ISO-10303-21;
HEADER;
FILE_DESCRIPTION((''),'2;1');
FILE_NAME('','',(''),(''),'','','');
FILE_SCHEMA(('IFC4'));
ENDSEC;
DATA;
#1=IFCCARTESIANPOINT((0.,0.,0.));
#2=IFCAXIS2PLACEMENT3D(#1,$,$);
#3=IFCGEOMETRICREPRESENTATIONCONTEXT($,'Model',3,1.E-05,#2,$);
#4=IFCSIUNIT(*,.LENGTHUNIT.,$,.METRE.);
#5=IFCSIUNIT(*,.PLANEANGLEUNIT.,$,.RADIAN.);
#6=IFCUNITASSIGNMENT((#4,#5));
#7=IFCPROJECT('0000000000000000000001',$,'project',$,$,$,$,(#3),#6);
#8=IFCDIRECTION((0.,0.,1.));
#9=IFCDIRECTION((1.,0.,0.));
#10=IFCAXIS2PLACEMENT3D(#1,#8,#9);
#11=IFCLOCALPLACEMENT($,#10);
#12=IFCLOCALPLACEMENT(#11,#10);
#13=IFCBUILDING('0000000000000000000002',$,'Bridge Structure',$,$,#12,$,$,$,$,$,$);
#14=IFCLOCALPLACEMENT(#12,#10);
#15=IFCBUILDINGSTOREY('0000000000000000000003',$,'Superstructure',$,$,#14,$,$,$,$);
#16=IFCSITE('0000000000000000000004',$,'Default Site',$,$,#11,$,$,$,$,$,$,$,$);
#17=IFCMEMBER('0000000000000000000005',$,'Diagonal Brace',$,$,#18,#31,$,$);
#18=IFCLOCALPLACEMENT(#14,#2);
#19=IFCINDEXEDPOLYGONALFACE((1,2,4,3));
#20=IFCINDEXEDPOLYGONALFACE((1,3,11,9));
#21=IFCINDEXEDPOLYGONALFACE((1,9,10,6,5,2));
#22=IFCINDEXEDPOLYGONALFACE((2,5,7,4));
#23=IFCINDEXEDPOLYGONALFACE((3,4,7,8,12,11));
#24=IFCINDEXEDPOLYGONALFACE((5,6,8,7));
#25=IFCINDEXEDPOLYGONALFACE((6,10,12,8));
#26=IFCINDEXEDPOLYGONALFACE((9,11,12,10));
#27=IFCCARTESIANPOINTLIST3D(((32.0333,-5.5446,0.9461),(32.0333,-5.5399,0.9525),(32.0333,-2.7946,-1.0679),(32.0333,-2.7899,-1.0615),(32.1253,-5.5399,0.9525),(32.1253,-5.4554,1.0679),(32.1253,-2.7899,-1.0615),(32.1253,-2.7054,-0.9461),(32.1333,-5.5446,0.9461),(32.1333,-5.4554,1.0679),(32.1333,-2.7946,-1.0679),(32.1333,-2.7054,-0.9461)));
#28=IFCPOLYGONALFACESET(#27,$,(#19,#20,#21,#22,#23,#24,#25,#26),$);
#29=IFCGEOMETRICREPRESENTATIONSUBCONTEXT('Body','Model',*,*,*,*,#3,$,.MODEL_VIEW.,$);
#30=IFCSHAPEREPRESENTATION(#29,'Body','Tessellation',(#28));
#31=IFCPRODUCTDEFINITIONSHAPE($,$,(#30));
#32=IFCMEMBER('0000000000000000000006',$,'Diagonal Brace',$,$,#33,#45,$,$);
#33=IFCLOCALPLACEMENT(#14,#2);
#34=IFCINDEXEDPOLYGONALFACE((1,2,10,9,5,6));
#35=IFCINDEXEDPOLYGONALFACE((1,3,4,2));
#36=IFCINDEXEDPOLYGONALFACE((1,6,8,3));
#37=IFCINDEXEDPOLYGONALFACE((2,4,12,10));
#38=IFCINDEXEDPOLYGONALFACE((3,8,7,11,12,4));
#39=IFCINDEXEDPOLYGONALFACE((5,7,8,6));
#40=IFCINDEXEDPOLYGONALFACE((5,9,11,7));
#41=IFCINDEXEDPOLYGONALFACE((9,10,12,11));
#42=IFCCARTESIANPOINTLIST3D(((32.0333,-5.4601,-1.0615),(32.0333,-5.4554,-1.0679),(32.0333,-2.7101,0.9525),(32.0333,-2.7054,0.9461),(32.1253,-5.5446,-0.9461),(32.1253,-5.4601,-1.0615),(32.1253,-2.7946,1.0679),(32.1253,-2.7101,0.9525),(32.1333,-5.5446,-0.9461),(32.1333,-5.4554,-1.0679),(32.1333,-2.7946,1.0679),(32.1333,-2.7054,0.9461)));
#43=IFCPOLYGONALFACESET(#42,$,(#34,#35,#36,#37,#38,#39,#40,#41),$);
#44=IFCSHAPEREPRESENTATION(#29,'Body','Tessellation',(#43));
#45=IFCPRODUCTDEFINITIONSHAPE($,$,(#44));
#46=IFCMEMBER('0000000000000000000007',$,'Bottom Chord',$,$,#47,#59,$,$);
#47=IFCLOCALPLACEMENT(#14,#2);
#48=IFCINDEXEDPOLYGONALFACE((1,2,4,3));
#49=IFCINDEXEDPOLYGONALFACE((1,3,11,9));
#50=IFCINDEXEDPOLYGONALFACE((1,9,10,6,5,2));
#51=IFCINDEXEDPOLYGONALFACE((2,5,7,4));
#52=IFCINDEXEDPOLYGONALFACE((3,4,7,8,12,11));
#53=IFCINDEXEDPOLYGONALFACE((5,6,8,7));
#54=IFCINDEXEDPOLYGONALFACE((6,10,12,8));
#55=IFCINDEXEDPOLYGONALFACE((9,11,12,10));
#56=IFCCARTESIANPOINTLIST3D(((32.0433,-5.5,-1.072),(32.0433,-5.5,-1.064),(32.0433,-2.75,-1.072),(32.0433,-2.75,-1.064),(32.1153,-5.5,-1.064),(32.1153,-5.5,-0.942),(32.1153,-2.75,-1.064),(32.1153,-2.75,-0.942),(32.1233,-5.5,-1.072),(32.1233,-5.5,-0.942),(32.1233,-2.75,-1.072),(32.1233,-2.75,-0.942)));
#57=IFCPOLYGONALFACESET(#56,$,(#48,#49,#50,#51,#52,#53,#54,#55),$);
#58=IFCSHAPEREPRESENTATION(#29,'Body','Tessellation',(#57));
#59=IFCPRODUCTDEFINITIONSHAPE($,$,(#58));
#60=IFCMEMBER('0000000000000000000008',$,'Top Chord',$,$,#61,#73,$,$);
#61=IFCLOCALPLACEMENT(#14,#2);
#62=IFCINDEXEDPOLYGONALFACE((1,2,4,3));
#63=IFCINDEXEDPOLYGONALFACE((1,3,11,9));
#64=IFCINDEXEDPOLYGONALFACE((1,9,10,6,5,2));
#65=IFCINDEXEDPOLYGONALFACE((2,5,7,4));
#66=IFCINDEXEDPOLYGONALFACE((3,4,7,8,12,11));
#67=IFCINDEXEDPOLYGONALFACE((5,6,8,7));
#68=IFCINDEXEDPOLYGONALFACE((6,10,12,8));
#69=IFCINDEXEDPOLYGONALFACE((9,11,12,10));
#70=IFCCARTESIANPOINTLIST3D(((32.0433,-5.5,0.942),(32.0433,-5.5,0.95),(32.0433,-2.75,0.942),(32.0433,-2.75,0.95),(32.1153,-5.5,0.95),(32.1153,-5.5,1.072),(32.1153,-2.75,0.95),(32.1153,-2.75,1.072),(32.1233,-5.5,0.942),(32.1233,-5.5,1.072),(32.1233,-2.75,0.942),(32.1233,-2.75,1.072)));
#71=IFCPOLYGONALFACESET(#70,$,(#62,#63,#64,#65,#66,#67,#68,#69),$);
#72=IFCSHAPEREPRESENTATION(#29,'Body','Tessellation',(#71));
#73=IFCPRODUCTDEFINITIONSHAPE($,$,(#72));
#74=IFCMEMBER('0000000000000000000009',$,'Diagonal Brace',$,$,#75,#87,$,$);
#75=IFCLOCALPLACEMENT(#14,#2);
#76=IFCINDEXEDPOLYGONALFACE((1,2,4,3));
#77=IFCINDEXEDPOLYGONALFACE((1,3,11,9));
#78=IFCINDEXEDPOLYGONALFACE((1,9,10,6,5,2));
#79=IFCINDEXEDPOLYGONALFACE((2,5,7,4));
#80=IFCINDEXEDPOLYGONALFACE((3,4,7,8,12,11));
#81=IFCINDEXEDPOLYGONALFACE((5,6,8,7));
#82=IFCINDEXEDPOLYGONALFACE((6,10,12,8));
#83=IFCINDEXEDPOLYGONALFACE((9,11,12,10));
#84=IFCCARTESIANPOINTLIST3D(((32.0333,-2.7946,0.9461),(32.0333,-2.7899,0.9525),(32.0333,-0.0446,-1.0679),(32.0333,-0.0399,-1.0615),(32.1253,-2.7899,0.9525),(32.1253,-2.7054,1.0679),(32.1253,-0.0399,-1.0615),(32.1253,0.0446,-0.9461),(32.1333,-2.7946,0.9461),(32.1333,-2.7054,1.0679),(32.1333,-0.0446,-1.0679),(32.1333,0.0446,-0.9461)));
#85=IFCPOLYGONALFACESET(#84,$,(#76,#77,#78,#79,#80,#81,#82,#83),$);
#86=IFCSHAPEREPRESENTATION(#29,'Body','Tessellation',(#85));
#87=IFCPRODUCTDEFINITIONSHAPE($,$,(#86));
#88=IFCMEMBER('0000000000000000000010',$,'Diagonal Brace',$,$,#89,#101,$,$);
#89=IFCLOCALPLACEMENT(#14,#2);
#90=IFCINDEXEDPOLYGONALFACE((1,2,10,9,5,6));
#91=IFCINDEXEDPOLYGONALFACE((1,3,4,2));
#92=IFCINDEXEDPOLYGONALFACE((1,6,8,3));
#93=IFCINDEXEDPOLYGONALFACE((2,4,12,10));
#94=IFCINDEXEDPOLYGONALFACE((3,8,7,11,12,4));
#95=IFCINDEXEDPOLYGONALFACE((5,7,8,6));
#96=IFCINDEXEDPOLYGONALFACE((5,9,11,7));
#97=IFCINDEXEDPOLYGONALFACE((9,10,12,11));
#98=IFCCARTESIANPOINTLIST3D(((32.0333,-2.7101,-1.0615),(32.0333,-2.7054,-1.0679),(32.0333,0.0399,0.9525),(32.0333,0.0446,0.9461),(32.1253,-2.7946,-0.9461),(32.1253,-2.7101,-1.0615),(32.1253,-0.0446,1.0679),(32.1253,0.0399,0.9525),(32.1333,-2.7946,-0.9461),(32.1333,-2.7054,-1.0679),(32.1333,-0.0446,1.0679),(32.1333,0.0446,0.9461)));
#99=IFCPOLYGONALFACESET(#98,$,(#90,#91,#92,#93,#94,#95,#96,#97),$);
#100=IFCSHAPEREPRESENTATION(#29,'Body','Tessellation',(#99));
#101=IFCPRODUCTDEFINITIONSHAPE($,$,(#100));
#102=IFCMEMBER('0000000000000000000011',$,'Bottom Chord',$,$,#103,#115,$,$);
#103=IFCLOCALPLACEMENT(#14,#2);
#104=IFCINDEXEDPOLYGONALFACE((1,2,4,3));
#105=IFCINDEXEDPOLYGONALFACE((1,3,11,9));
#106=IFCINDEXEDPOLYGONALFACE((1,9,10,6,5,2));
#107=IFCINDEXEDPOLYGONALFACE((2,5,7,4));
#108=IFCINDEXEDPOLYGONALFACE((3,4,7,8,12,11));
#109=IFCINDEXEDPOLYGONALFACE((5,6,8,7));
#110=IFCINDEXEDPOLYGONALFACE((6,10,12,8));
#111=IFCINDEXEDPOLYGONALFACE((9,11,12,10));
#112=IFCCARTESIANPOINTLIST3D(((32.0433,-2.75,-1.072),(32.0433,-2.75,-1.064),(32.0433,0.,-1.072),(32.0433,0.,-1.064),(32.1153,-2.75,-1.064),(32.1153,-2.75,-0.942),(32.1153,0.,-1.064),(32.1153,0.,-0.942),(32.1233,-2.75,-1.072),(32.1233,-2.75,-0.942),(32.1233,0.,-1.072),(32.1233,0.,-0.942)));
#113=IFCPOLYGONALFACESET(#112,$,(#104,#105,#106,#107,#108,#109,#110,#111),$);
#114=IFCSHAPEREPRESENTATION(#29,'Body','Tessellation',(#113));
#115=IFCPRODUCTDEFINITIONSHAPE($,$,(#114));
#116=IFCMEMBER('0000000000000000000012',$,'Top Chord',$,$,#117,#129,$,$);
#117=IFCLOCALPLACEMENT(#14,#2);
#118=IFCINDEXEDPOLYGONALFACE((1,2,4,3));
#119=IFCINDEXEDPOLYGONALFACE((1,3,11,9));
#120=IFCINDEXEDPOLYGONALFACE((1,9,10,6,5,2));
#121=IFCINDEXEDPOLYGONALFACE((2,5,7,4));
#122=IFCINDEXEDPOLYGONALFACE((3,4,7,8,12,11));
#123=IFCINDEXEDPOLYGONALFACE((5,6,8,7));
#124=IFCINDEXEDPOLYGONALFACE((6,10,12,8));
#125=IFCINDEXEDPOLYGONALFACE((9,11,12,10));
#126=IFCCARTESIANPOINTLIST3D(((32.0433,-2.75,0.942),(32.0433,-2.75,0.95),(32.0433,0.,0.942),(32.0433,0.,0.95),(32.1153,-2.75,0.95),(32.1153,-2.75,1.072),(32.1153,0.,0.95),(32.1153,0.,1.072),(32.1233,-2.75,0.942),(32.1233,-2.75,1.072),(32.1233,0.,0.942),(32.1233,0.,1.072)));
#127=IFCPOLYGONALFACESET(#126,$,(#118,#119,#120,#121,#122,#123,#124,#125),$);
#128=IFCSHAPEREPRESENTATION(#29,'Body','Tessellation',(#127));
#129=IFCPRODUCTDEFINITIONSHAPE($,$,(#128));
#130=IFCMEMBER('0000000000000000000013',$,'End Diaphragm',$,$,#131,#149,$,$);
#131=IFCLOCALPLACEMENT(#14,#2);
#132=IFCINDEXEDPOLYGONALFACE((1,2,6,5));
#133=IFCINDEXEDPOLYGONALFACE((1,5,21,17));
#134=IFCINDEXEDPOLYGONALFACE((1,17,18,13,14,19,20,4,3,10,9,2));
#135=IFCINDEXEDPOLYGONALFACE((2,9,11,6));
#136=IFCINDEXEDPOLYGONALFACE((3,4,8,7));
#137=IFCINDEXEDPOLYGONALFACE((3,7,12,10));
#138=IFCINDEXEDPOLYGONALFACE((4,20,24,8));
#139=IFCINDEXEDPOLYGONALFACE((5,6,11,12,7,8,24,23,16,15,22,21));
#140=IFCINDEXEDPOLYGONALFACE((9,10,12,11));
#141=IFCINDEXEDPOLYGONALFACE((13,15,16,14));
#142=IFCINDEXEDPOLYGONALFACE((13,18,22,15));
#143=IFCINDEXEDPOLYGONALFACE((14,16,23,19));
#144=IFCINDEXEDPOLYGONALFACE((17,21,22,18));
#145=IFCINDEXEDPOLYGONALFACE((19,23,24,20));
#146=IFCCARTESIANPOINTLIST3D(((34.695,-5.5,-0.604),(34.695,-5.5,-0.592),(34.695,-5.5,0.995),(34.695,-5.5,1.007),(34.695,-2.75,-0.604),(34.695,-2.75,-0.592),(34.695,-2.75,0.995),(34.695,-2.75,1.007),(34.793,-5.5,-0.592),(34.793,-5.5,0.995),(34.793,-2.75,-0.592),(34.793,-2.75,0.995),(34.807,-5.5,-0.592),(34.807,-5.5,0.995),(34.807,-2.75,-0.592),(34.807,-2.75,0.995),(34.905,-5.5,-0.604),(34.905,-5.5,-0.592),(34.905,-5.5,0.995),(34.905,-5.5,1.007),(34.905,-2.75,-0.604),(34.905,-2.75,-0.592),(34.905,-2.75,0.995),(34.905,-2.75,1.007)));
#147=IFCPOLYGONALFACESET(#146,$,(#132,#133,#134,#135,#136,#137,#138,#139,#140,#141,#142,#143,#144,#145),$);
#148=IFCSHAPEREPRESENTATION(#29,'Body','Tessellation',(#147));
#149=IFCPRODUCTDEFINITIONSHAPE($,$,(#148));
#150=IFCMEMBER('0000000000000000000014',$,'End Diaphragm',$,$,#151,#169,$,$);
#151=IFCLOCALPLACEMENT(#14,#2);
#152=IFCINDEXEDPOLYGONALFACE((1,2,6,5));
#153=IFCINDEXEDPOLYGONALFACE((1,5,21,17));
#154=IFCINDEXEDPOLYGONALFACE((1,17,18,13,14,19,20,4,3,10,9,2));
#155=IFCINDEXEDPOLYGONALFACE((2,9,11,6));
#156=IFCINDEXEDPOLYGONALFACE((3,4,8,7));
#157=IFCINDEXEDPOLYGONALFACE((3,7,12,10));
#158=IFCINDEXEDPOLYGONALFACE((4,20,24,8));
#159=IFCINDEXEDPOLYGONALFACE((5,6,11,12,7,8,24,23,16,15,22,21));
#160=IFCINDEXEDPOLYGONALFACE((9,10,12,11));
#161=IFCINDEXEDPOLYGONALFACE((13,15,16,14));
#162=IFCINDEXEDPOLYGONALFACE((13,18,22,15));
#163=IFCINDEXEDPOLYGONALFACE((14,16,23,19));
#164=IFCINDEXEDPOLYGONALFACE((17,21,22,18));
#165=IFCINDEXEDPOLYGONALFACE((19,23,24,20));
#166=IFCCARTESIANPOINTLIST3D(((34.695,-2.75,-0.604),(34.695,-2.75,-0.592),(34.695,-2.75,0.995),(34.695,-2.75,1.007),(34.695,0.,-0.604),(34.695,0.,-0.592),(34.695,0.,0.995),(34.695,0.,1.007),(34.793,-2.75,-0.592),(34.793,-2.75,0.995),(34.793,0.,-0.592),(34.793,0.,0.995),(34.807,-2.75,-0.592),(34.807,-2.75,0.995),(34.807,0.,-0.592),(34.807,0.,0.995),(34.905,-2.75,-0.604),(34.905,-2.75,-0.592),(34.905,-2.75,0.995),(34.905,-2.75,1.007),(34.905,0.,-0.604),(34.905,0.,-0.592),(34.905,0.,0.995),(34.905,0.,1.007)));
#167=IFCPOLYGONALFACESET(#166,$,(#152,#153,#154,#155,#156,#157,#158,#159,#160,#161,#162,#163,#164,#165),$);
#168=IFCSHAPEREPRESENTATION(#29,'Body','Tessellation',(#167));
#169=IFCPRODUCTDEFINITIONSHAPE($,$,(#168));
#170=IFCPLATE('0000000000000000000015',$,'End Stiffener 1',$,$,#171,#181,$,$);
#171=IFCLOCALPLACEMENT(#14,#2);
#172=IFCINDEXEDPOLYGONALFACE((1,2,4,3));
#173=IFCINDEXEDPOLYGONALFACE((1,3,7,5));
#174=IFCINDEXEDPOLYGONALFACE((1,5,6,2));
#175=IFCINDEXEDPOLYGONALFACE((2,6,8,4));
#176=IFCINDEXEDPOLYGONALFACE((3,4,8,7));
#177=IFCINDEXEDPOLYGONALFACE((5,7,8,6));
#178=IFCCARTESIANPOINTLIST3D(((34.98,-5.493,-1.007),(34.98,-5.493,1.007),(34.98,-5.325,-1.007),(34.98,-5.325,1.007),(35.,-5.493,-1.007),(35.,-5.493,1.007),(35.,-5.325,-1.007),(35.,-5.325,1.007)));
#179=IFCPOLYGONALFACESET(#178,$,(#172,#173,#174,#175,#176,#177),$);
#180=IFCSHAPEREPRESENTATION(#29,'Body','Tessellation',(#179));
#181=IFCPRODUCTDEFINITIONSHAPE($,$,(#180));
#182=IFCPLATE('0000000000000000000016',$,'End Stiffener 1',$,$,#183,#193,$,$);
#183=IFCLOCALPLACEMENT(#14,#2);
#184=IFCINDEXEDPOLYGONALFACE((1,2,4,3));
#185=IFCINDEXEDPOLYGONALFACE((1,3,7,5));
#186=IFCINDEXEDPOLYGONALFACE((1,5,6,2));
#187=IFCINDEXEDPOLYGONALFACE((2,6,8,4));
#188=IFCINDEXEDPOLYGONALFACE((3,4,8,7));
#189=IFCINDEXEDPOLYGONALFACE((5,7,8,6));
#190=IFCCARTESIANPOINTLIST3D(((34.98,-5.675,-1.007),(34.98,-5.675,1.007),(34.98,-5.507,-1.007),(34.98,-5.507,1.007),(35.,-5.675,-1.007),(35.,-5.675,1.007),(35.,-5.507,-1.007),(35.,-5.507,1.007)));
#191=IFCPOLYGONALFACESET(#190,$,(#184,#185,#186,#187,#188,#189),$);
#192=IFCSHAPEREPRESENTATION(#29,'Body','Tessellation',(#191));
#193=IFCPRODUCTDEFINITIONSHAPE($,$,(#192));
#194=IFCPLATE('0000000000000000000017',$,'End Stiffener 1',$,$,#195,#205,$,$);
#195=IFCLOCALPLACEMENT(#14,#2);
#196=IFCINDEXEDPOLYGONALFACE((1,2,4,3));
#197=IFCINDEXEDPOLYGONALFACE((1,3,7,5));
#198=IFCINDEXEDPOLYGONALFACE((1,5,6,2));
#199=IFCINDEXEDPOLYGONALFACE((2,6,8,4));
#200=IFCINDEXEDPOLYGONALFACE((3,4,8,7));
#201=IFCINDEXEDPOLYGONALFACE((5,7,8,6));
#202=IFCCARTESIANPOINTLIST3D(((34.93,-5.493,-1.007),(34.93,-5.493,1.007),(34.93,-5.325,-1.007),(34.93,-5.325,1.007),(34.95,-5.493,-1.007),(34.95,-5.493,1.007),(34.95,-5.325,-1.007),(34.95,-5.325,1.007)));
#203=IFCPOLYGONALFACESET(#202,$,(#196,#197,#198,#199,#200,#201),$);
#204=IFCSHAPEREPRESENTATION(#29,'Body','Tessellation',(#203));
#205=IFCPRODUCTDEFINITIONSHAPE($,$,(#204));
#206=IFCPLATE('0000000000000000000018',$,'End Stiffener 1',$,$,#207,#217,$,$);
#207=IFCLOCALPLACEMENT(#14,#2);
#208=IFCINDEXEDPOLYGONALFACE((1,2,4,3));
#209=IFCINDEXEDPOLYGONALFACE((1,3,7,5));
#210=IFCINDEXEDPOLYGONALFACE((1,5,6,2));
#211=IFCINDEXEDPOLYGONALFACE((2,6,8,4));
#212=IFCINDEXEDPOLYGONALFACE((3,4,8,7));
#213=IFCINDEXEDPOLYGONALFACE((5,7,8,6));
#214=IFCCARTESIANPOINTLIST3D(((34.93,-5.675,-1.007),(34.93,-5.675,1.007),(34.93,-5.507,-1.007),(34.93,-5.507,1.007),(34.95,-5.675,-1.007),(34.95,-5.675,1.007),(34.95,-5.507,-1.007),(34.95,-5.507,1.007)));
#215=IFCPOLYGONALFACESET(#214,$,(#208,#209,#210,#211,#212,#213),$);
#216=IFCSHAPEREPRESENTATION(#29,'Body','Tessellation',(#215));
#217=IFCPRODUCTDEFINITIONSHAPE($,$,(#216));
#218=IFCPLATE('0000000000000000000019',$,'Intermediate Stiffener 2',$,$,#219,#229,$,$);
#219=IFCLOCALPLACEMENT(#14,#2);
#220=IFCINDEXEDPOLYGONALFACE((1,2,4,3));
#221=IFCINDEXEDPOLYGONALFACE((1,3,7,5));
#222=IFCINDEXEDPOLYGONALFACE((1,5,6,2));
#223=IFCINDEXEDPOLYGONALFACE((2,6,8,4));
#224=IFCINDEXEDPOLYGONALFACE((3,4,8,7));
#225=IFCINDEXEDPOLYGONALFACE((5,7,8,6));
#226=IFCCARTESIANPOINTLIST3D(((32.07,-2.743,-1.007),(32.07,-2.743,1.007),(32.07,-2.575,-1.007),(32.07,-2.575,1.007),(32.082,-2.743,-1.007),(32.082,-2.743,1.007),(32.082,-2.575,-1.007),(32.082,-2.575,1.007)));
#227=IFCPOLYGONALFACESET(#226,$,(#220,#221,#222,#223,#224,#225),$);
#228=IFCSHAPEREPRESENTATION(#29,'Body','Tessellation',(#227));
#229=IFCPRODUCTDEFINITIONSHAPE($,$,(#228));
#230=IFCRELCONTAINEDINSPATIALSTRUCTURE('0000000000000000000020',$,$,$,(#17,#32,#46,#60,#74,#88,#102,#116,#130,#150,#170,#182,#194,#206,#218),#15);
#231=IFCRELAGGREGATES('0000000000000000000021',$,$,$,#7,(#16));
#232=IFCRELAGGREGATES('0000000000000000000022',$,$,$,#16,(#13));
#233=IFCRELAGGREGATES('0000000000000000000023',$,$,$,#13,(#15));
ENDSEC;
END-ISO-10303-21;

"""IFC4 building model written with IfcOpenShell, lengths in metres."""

from ifc_helpers import new_model, si_unit, frame, origin, origin_with_axes, origin_2d_with_axis, place, context, subcontext, project, spatial, rectangle, i_section, l_section, extrude, element, save


model = new_model("IFC4")

# Units and contexts
model_context = context("Model", 3, precision=1e-05, world=origin())
body_context = subcontext(model_context, "Body", "Model", "MODEL_VIEW")
ifc_project = project(units=[si_unit("LENGTHUNIT", "METRE"), si_unit("PLANEANGLEUNIT", "RADIAN")], contexts=[model_context])

# Site, building, storey
site_placement = place(None, origin_with_axes())
site = spatial("IfcSite", under=ifc_project, at=site_placement, Name="Default Site")
building_placement = place(site_placement, origin_with_axes())
building = spatial("IfcBuilding", under=site, at=building_placement, Name="Bridge Structure")
storey_placement = place(building_placement, origin_with_axes())
storey = spatial("IfcBuildingStorey", under=building, at=storey_placement, Name="Superstructure")

# Members
for number, where, z_axis, x_axis, name in (
    (1, (32.0833, -5.5, 1.007), (0.0, 0.806778, -0.590855), (-1.0, 0.0, 0.0), "Diagonal Brace"),
    (2, (32.0833, -5.5, -1.007), (0.0, 0.806778, 0.590855), (-1.0, 0.0, 0.0), "Diagonal Brace"),
):
    element("IfcMember", number, at=place(storey_placement, frame(where, z_axis=z_axis, x_axis=x_axis)), inside=storey, Name=name, context=body_context, shape_type="SweptSolid", body=[
        extrude(l_section(Depth=0.151, Width=0.1, Thickness=0.008, at=origin_2d_with_axis()), origin_with_axes(), (0.0, 0.0, 1.0), 3.4086),
    ])
for number, where, z_axis, x_axis, name in (
    (3, (32.0833, -5.5, -1.007), (0.0, 1.0, 0.0), (-1.0, 0.0, 0.0), "Bottom Chord"),
    (4, (32.0833, -5.5, 1.007), (0.0, 1.0, 0.0), (-1.0, 0.0, 0.0), "Top Chord"),
):
    element("IfcMember", number, at=place(storey_placement, frame(where, z_axis=z_axis, x_axis=x_axis)), inside=storey, Name=name, context=body_context, shape_type="SweptSolid", body=[
        extrude(l_section(Depth=0.13, Width=0.08, Thickness=0.008, at=origin_2d_with_axis()), origin_with_axes(), (0.0, 0.0, 1.0), 2.75),
    ])
for number, where, z_axis, x_axis, name in (
    (5, (32.0833, -2.75, 1.007), (0.0, 0.806778, -0.590855), (-1.0, 0.0, 0.0), "Diagonal Brace"),
    (6, (32.0833, -2.75, -1.007), (0.0, 0.806778, 0.590855), (-1.0, 0.0, 0.0), "Diagonal Brace"),
):
    element("IfcMember", number, at=place(storey_placement, frame(where, z_axis=z_axis, x_axis=x_axis)), inside=storey, Name=name, context=body_context, shape_type="SweptSolid", body=[
        extrude(l_section(Depth=0.151, Width=0.1, Thickness=0.008, at=origin_2d_with_axis()), origin_with_axes(), (0.0, 0.0, 1.0), 3.4086),
    ])
for number, where, z_axis, x_axis, name in (
    (7, (32.0833, -2.75, -1.007), (0.0, 1.0, 0.0), (-1.0, 0.0, 0.0), "Bottom Chord"),
    (8, (32.0833, -2.75, 1.007), (0.0, 1.0, 0.0), (-1.0, 0.0, 0.0), "Top Chord"),
):
    element("IfcMember", number, at=place(storey_placement, frame(where, z_axis=z_axis, x_axis=x_axis)), inside=storey, Name=name, context=body_context, shape_type="SweptSolid", body=[
        extrude(l_section(Depth=0.13, Width=0.08, Thickness=0.008, at=origin_2d_with_axis()), origin_with_axes(), (0.0, 0.0, 1.0), 2.75),
    ])
for number, where, z_axis, x_axis, name in (
    (9, (34.8, -5.5, 0.2015), (0.0, 1.0, 0.0), (-1.0, 0.0, 0.0), "End Diaphragm"),
    (10, (34.8, -2.75, 0.2015), (0.0, 1.0, 0.0), (-1.0, 0.0, 0.0), "End Diaphragm"),
):
    element("IfcMember", number, at=place(storey_placement, frame(where, z_axis=z_axis, x_axis=x_axis)), inside=storey, Name=name, context=body_context, shape_type="SweptSolid", body=[
        extrude(i_section(OverallWidth=0.21, OverallDepth=1.611, WebThickness=0.014, FlangeThickness=0.012, at=origin_2d_with_axis()), origin_with_axes(), (0.0, 0.0, 1.0), 2.75),
    ])

# Plates
for number, where, z_axis, x_axis, name in (
    (11, (34.99, -5.409, -1.007), (0.0, 0.0, 1.0), (1.0, 0.0, 0.0), "End Stiffener 1"),
    (12, (34.99, -5.591, -1.007), (0.0, 0.0, 1.0), (1.0, 0.0, 0.0), "End Stiffener 1"),
    (13, (34.94, -5.409, -1.007), (0.0, 0.0, 1.0), (1.0, 0.0, 0.0), "End Stiffener 1"),
    (14, (34.94, -5.591, -1.007), (0.0, 0.0, 1.0), (1.0, 0.0, 0.0), "End Stiffener 1"),
):
    element("IfcPlate", number, at=place(storey_placement, frame(where, z_axis=z_axis, x_axis=x_axis)), inside=storey, Name=name, context=body_context, shape_type="SweptSolid", body=[
        extrude(rectangle(XDim=0.02, YDim=0.168, at=origin_2d_with_axis()), origin_with_axes(), (0.0, 0.0, 1.0), 2.014),
    ])
plate_1_placement = place(storey_placement, frame((32.076, -2.659, -1.007), z_axis=(0.0, 0.0, 1.0), x_axis=(1.0, 0.0, 0.0)))
element("IfcPlate", 15, at=plate_1_placement, inside=storey, Name="Intermediate Stiffener 2", context=body_context, shape_type="SweptSolid", body=[
    extrude(rectangle(XDim=0.012, YDim=0.168, at=origin_2d_with_axis()), origin_with_axes(), (0.0, 0.0, 1.0), 2.014),
])

save(model, "model.ifc")
